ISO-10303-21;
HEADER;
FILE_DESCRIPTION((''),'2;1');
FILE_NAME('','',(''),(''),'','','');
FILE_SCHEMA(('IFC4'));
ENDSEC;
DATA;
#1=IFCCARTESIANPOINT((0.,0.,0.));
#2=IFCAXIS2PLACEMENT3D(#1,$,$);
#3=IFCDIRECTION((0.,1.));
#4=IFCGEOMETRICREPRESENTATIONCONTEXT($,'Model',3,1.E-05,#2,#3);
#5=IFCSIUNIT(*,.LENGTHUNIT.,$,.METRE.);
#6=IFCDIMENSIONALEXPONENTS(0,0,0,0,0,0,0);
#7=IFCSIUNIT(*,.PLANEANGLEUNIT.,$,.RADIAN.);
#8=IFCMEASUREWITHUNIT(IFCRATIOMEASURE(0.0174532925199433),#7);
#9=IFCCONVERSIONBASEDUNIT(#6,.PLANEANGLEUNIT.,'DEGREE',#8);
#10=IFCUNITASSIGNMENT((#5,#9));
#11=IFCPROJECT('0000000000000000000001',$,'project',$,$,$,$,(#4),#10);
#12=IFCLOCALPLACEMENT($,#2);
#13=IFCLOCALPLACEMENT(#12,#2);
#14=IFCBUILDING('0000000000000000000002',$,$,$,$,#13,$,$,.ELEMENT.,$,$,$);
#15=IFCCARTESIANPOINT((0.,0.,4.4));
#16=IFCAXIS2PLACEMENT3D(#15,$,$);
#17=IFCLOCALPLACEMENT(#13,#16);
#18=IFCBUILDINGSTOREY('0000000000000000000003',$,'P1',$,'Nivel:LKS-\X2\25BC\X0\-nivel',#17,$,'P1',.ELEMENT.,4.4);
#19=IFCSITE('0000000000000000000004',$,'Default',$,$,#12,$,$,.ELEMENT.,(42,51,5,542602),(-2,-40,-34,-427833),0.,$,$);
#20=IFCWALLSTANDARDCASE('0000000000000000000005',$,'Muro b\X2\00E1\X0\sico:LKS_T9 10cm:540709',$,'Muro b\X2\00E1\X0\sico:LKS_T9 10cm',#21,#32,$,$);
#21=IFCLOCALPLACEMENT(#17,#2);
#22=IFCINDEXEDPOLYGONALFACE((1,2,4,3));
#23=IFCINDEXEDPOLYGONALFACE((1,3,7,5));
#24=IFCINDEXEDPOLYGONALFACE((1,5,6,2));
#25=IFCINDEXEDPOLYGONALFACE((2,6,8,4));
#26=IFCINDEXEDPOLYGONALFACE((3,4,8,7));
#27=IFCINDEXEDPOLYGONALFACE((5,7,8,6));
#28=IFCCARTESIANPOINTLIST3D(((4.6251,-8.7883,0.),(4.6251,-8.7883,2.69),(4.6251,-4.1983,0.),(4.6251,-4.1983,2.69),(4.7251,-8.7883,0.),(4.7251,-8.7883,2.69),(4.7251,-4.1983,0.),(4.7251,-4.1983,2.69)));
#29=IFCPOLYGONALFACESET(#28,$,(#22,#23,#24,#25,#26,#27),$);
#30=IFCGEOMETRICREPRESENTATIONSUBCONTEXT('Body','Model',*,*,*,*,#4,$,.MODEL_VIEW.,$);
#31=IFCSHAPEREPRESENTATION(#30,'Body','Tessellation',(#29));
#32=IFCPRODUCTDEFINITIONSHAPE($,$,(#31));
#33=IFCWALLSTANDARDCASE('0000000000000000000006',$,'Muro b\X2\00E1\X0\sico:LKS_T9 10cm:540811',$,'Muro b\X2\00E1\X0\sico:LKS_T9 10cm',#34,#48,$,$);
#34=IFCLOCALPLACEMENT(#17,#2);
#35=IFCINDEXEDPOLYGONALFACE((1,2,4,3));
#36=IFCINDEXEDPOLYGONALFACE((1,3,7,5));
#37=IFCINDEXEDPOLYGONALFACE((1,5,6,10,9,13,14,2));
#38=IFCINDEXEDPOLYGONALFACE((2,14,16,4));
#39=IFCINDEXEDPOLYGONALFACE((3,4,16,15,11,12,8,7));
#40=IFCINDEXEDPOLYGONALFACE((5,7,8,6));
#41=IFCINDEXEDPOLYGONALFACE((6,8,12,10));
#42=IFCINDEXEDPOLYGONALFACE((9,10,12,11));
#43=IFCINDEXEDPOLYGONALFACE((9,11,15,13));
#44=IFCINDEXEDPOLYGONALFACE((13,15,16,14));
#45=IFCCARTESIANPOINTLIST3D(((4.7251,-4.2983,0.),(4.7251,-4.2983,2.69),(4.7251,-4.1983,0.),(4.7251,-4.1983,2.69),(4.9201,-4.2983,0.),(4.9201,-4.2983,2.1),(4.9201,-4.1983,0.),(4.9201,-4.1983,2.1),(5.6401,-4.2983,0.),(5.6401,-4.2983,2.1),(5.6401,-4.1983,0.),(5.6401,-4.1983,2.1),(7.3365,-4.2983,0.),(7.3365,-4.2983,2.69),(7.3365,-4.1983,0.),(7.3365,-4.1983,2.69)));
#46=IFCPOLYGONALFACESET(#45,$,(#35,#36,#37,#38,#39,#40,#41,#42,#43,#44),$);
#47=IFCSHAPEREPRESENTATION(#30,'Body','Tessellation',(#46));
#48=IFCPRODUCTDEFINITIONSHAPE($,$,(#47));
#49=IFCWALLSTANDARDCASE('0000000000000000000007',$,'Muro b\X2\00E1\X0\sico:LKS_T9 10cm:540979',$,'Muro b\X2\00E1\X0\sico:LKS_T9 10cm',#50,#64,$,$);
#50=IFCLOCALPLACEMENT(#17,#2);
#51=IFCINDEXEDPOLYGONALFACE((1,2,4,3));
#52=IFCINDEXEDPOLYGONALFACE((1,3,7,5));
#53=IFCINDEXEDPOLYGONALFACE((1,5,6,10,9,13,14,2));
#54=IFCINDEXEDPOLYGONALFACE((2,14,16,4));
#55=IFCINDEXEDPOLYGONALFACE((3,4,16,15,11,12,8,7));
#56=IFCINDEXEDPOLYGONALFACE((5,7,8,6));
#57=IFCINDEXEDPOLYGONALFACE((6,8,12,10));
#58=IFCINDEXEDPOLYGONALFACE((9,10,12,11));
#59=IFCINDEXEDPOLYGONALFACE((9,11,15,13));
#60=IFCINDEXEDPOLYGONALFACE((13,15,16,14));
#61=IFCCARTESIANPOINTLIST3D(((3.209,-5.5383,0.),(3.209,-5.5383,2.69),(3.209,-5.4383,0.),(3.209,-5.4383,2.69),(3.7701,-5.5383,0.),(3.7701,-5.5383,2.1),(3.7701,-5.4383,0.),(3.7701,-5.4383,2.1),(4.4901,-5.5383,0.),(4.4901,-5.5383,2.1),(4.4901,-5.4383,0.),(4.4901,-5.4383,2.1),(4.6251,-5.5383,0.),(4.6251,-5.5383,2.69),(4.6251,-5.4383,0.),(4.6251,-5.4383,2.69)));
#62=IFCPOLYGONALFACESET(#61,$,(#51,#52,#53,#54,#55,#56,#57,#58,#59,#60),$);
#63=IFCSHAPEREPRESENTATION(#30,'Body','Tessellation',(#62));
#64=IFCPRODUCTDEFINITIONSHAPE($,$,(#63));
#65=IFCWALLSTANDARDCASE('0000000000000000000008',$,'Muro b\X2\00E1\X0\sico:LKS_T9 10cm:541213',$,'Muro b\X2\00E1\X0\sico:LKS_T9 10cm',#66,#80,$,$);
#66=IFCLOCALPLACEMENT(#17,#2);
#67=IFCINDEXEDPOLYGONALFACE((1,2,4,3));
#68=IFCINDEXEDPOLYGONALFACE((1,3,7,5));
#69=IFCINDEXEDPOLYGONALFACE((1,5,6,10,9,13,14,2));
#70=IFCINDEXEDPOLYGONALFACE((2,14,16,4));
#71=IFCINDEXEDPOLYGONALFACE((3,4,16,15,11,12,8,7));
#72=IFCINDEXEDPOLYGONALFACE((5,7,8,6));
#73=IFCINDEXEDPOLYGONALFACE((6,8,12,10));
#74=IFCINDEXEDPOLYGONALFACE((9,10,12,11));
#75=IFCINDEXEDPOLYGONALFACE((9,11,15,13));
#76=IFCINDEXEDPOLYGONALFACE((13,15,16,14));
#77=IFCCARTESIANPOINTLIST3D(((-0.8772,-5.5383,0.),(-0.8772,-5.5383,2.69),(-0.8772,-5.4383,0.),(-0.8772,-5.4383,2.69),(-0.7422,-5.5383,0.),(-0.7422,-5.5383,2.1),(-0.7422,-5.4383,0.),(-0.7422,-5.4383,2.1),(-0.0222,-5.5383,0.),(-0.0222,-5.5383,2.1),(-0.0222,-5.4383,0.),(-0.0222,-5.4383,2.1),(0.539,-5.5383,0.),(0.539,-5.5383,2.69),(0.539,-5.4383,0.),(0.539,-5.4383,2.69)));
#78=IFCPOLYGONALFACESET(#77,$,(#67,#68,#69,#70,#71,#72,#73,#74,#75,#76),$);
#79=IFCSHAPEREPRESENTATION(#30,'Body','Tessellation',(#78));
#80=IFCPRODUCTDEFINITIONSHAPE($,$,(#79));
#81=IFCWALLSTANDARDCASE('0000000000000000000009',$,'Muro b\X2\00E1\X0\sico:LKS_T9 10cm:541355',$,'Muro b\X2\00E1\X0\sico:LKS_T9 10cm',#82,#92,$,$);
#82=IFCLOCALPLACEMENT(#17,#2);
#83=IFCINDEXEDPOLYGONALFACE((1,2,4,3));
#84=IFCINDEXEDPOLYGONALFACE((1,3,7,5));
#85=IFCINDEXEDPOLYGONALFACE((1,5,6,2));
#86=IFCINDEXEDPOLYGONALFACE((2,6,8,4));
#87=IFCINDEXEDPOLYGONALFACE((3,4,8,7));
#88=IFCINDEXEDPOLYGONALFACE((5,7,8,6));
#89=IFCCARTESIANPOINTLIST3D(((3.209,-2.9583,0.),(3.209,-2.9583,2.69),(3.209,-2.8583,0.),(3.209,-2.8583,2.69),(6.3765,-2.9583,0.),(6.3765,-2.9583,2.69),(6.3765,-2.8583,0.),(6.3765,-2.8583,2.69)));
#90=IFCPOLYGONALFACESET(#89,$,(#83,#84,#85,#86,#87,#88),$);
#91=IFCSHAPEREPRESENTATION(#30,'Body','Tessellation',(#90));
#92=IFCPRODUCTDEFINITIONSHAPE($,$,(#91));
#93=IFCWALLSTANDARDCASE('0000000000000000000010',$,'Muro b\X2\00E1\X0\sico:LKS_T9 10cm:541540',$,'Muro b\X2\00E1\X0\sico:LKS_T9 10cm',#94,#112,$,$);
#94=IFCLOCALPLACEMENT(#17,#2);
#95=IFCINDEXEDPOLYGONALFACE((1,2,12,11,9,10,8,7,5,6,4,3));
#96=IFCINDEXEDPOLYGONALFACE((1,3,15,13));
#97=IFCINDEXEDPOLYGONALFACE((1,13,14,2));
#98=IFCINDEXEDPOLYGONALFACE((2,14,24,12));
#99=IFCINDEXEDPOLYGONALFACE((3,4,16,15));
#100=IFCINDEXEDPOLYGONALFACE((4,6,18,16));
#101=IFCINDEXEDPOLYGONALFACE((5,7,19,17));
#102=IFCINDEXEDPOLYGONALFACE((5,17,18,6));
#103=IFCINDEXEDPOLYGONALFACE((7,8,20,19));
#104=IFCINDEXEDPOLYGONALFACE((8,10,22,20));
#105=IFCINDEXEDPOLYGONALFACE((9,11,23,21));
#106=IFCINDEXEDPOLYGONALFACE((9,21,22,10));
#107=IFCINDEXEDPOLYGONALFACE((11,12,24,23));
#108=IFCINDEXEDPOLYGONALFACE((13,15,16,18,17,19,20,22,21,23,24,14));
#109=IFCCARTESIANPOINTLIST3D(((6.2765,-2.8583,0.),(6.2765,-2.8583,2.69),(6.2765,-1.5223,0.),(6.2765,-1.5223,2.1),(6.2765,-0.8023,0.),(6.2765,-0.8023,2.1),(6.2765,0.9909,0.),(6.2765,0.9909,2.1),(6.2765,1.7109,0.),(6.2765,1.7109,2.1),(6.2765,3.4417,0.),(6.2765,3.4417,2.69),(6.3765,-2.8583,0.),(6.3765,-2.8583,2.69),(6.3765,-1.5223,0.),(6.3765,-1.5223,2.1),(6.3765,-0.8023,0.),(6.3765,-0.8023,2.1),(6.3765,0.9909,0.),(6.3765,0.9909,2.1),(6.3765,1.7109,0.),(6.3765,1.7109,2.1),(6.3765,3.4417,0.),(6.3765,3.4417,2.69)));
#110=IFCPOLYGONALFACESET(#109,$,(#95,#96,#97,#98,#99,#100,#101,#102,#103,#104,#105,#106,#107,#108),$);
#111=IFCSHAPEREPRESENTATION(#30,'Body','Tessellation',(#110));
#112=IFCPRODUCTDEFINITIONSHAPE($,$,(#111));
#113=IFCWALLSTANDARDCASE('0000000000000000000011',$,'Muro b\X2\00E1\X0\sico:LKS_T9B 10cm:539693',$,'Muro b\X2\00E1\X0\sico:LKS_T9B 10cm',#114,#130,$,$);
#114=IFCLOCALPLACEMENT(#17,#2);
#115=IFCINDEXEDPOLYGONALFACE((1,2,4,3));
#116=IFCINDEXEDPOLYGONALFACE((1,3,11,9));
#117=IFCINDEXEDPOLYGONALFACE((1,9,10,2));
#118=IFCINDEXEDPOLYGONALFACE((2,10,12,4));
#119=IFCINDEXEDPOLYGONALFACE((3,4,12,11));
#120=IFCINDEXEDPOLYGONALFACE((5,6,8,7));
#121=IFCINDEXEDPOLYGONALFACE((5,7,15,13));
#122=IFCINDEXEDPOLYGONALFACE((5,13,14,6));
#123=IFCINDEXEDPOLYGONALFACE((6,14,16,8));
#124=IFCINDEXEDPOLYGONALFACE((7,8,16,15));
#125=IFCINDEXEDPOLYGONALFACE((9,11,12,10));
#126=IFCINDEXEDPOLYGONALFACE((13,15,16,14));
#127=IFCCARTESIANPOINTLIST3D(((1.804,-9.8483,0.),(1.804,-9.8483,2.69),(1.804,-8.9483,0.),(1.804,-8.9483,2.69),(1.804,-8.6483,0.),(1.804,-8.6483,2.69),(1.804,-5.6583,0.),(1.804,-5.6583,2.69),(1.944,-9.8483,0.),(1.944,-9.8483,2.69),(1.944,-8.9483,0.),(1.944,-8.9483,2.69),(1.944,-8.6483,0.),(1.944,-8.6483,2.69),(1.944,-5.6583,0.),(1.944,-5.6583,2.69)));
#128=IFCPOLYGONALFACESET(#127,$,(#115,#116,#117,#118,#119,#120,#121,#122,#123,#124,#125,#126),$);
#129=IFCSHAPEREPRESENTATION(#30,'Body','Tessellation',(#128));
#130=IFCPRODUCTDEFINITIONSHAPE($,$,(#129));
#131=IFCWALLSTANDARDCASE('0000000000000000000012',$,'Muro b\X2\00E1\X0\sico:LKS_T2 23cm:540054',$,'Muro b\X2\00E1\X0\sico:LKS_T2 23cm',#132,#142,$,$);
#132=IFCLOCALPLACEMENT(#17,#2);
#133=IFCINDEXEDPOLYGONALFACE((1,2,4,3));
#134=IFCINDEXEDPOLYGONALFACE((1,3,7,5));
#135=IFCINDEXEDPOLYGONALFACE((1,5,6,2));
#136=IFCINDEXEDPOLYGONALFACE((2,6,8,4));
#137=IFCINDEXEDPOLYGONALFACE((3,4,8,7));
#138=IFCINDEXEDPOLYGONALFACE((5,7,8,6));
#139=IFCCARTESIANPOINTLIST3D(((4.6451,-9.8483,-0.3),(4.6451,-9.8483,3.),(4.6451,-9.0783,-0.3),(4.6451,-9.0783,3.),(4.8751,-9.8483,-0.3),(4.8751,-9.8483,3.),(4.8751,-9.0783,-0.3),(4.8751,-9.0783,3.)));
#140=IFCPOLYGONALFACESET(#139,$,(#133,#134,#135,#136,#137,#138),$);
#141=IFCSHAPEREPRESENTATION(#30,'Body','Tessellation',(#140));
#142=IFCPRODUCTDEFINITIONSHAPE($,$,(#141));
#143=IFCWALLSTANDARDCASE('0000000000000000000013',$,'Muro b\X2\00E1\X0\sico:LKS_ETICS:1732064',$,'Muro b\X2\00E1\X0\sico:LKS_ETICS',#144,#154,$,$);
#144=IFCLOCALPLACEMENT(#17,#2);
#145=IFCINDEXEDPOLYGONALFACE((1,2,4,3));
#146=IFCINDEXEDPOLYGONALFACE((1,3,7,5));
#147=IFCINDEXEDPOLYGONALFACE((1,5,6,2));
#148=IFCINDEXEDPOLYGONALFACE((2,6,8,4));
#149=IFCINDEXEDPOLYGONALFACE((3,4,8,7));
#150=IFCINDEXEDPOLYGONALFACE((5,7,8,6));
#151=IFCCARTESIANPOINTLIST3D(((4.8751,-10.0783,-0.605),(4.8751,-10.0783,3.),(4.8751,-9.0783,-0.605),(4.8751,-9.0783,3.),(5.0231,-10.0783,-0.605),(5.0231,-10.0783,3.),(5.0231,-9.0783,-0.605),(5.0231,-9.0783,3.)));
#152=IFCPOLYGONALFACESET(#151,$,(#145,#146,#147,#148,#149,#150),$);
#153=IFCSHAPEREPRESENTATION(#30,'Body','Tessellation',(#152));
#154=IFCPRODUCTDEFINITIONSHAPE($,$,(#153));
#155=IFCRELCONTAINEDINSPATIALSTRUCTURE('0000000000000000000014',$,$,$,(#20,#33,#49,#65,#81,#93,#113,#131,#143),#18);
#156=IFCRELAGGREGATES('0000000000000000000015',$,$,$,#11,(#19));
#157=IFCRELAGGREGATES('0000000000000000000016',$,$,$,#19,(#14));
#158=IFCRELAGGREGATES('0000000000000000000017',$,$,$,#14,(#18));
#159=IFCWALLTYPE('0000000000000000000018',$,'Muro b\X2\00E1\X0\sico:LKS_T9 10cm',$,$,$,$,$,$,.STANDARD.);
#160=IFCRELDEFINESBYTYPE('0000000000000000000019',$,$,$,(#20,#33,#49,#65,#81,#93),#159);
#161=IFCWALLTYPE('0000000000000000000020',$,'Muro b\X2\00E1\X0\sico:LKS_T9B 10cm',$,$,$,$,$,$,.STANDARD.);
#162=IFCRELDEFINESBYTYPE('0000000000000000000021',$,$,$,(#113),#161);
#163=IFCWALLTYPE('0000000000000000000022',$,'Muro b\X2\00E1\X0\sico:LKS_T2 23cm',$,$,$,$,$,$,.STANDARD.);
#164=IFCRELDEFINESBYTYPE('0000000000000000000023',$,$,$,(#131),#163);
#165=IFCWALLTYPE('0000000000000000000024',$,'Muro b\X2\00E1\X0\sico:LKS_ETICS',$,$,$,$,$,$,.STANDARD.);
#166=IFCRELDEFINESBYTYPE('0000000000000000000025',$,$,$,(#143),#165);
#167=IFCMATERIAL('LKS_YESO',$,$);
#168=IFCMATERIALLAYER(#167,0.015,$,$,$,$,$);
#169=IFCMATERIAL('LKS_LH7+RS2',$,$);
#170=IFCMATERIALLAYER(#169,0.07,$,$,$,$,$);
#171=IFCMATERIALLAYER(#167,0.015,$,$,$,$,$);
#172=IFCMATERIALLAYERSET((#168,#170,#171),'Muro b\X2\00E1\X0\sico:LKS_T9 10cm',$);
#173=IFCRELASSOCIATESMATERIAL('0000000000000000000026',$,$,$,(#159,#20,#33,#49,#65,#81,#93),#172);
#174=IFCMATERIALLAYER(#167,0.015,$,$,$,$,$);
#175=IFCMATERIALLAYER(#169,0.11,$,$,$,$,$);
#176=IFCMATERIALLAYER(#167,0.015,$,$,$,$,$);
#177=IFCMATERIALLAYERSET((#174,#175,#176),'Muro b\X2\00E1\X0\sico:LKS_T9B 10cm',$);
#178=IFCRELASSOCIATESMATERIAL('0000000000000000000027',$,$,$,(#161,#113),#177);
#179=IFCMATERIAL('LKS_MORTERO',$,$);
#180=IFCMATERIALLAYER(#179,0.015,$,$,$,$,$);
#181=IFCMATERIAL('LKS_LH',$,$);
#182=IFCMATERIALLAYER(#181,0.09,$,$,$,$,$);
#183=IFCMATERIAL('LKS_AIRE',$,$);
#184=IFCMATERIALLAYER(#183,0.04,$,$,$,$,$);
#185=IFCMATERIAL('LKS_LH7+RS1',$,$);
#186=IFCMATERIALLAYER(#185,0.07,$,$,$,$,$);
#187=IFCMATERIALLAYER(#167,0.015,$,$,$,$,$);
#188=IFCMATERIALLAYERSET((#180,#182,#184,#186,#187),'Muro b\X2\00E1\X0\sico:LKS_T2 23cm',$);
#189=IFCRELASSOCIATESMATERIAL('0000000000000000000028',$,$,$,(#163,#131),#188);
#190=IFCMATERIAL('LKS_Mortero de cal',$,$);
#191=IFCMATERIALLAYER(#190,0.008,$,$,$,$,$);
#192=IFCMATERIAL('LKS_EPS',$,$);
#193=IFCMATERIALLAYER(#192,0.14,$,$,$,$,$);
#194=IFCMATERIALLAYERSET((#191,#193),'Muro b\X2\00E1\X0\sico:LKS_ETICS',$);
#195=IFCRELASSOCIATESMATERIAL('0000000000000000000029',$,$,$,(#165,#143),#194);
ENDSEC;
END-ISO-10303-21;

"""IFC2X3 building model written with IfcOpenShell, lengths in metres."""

from ifc_helpers import new_model, entity, si_unit, converted_unit, direction, frame, frame_2d, origin, place, context, subcontext, project, spatial, rectangle, extrude, material, layer, layer_set, layer_usage, type_object, element, save


model = new_model("IFC2X3")

# Units and contexts
model_context = context("Model", 3, precision=1e-05, world=origin(), true_north=direction((0.0, 1.0)))
body_context = subcontext(model_context, "Body", "Model", "MODEL_VIEW")
ifc_project = project(units=[si_unit("LENGTHUNIT", "METRE"), converted_unit("PLANEANGLEUNIT", "DEGREE", entity("IfcRatioMeasure", 0.0174532925199433), si_unit("PLANEANGLEUNIT", "RADIAN"), dimensions=[0, 0, 0, 0, 0, 0, 0])], contexts=[model_context])

# Site, building, storey
site_placement = place(None, origin())
site = spatial("IfcSite", under=ifc_project, at=site_placement, Name="Default", CompositionType="ELEMENT", RefLatitude=(42, 51, 5, 542602), RefLongitude=(-2, -40, -34, -427833), RefElevation=0.0)
building_placement = place(site_placement, origin())
building = spatial("IfcBuilding", under=site, at=building_placement, CompositionType="ELEMENT")
storey_placement = place(building_placement, frame((0.0, 0.0, 4.4)))
storey = spatial("IfcBuildingStorey", under=building, at=storey_placement, Name="P1", ObjectType="Nivel:LKS-▼-nivel", LongName="P1", CompositionType="ELEMENT", Elevation=4.4)

# Shared definitions
ifc_material_1 = material(Name="LKS_MORTERO")
ifc_material_2 = material(Name="LKS_LH")
ifc_material_3 = material(Name="LKS_AIRE")
ifc_material_4 = material(Name="LKS_LH7+RS2")
ifc_material_5 = material(Name="LKS_YESO")

# Shared definitions
ifc_material_6 = material(Name="LKS_LH7+RS1")

# Wall
ifc_layer_1 = layer(ifc_material_5, 0.015)
ifc_layer_2 = layer(ifc_material_4, 0.07)
ifc_layer_3 = layer(ifc_material_5, 0.015)
ifc_layer_set_1 = layer_set([ifc_layer_1, ifc_layer_2, ifc_layer_3], Name="Muro básico:LKS_T9 10cm")
ifc_layer_usage_1 = layer_usage(ifc_layer_set_1, "AXIS2", "NEGATIVE", 0.05)
wall_type_1 = type_object("IfcWallType", Name="Muro básico:LKS_T9 10cm", PredefinedType="STANDARD", material=ifc_layer_set_1)
wall_1_placement = place(storey_placement, frame((4.6751, -8.7883, 0.0), z_axis=(0.0, 0.0, 1.0), x_axis=(0.0, 1.0, 0.0)))
element("IfcWallStandardCase", 1, at=wall_1_placement, inside=storey, type_object=wall_type_1, material=ifc_layer_usage_1, Name="Muro básico:LKS_T9 10cm:540709", ObjectType="Muro básico:LKS_T9 10cm", context=body_context, shape_type="SweptSolid", body=[
    extrude(rectangle(XDim=4.59, YDim=0.1, at=frame_2d((2.295, 0.0), x_axis=(-1.0, 0.0))), origin(), (0.0, 0.0, 1.0), 2.69),
])

# Walls, openings
ifc_layer_usage_2 = layer_usage(ifc_layer_set_1, "AXIS2", "NEGATIVE", 0.05)
wall_2_placement = place(storey_placement, frame((4.7251, -4.2483, 0.0)))
wall_2 = element("IfcWallStandardCase", 2, at=wall_2_placement, inside=storey, type_object=wall_type_1, material=ifc_layer_usage_2, Name="Muro básico:LKS_T9 10cm:540811", ObjectType="Muro básico:LKS_T9 10cm", context=body_context, shape_type="SweptSolid", body=[
    extrude(rectangle(XDim=2.6115, YDim=0.1, at=frame_2d((1.3057, 0.0), x_axis=(-1.0, 0.0))), origin(), (0.0, 0.0, 1.0), 2.69),
])
opening_1_placement = place(wall_2_placement, frame((0.915, 0.05, 0.0)))
element("IfcOpeningElement", 3, at=opening_1_placement, cuts=wall_2, ObjectType="Opening", context=body_context, shape_type="SweptSolid", body=[
    extrude(rectangle(XDim=2.1, YDim=0.72, at=frame_2d((1.05, 0.36), x_axis=(1.0, 0.0))), frame((0.0, 0.0, 0.0), z_axis=(0.0, -1.0, 0.0), x_axis=(0.0, 0.0, 1.0)), (0.0, 0.0, 1.0), 0.1),
])
ifc_layer_usage_3 = layer_usage(ifc_layer_set_1, "AXIS2", "POSITIVE", -0.05)
wall_3_placement = place(storey_placement, frame((3.209, -5.4883, 0.0)))
wall_3 = element("IfcWallStandardCase", 4, at=wall_3_placement, inside=storey, type_object=wall_type_1, material=ifc_layer_usage_3, Name="Muro básico:LKS_T9 10cm:540979", ObjectType="Muro básico:LKS_T9 10cm", context=body_context, shape_type="SweptSolid", body=[
    extrude(rectangle(XDim=1.4161, YDim=0.1, at=frame_2d((0.7081, 0.0), x_axis=(-1.0, 0.0))), origin(), (0.0, 0.0, 1.0), 2.69),
])
opening_2_placement = place(wall_3_placement, frame((1.2811, 0.05, 0.0)))
element("IfcOpeningElement", 5, at=opening_2_placement, cuts=wall_3, ObjectType="Opening", context=body_context, shape_type="SweptSolid", body=[
    extrude(rectangle(XDim=2.1, YDim=0.72, at=frame_2d((1.05, 0.36), x_axis=(1.0, 0.0))), frame((0.0, 0.0, 0.0), z_axis=(0.0, -1.0, 0.0), x_axis=(0.0, 0.0, 1.0)), (0.0, 0.0, 1.0), 0.1),
])
ifc_layer_usage_4 = layer_usage(ifc_layer_set_1, "AXIS2", "NEGATIVE", 0.05)
wall_4_placement = place(storey_placement, frame((0.539, -5.4883, 0.0), z_axis=(0.0, 0.0, 1.0), x_axis=(-1.0, 0.0, 0.0)))
wall_4 = element("IfcWallStandardCase", 6, at=wall_4_placement, inside=storey, type_object=wall_type_1, material=ifc_layer_usage_4, Name="Muro básico:LKS_T9 10cm:541213", ObjectType="Muro básico:LKS_T9 10cm", context=body_context, shape_type="SweptSolid", body=[
    extrude(rectangle(XDim=1.4161, YDim=0.1, at=frame_2d((0.7081, 0.0), x_axis=(-1.0, 0.0))), origin(), (0.0, 0.0, 1.0), 2.69),
])
opening_3_placement = place(wall_4_placement, frame((0.5611, -0.05, 0.0)))
element("IfcOpeningElement", 7, at=opening_3_placement, cuts=wall_4, ObjectType="Opening", context=body_context, shape_type="SweptSolid", body=[
    extrude(rectangle(XDim=2.1, YDim=0.72, at=frame_2d((1.05, 0.36), x_axis=(1.0, 0.0))), frame((0.0, 0.0, 0.0), z_axis=(0.0, 1.0, 0.0), x_axis=(0.0, 0.0, 1.0)), (0.0, 0.0, 1.0), 0.1),
])

# Wall
ifc_layer_usage_5 = layer_usage(ifc_layer_set_1, "AXIS2", "NEGATIVE", 0.05)
wall_5_placement = place(storey_placement, frame((3.209, -2.9083, 0.0)))
element("IfcWallStandardCase", 8, at=wall_5_placement, inside=storey, type_object=wall_type_1, material=ifc_layer_usage_5, Name="Muro básico:LKS_T9 10cm:541355", ObjectType="Muro básico:LKS_T9 10cm", context=body_context, shape_type="SweptSolid", body=[
    extrude(rectangle(XDim=3.1676, YDim=0.1, at=frame_2d((1.5838, 0.0), x_axis=(-1.0, 0.0))), origin(), (0.0, 0.0, 1.0), 2.69),
])

# Wall, openings
ifc_layer_usage_6 = layer_usage(ifc_layer_set_1, "AXIS2", "NEGATIVE", 0.05)
wall_6_placement = place(storey_placement, frame((6.3265, -2.8583, 0.0), z_axis=(0.0, 0.0, 1.0), x_axis=(0.0, 1.0, 0.0)))
wall_6 = element("IfcWallStandardCase", 9, at=wall_6_placement, inside=storey, type_object=wall_type_1, material=ifc_layer_usage_6, Name="Muro básico:LKS_T9 10cm:541540", ObjectType="Muro básico:LKS_T9 10cm", context=body_context, shape_type="SweptSolid", body=[
    extrude(rectangle(XDim=6.3, YDim=0.1, at=frame_2d((3.15, 0.0), x_axis=(-1.0, 0.0))), origin(), (0.0, 0.0, 1.0), 2.69),
])
opening_4_placement = place(wall_6_placement, frame((1.3359, -0.05, 0.0)))
element("IfcOpeningElement", 10, at=opening_4_placement, cuts=wall_6, ObjectType="Opening", context=body_context, shape_type="SweptSolid", body=[
    extrude(rectangle(XDim=2.1, YDim=0.72, at=frame_2d((1.05, 0.36), x_axis=(1.0, 0.0))), frame((0.0, 0.0, 0.0), z_axis=(0.0, 1.0, 0.0), x_axis=(0.0, 0.0, 1.0)), (0.0, 0.0, 1.0), 0.1),
])
opening_5_placement = place(wall_6_placement, frame((3.8492, -0.05, 0.0)))
element("IfcOpeningElement", 11, at=opening_5_placement, cuts=wall_6, ObjectType="Opening", context=body_context, shape_type="SweptSolid", body=[
    extrude(rectangle(XDim=2.1, YDim=0.72, at=frame_2d((1.05, 0.36), x_axis=(1.0, 0.0))), frame((0.0, 0.0, 0.0), z_axis=(0.0, 1.0, 0.0), x_axis=(0.0, 0.0, 1.0)), (0.0, 0.0, 1.0), 0.1),
])

# Wall, opening
ifc_layer_4 = layer(ifc_material_5, 0.015)
ifc_layer_5 = layer(ifc_material_4, 0.11)
ifc_layer_6 = layer(ifc_material_5, 0.015)
ifc_layer_set_2 = layer_set([ifc_layer_4, ifc_layer_5, ifc_layer_6], Name="Muro básico:LKS_T9B 10cm")
ifc_layer_usage_7 = layer_usage(ifc_layer_set_2, "AXIS2", "NEGATIVE", 0.07)
wall_type_2 = type_object("IfcWallType", Name="Muro básico:LKS_T9B 10cm", PredefinedType="STANDARD", material=ifc_layer_set_2)
wall_7_placement = place(storey_placement, frame((1.874, -5.6583, 0.0), z_axis=(0.0, 0.0, 1.0), x_axis=(0.0, -1.0, 0.0)))
wall_7 = element("IfcWallStandardCase", 12, at=wall_7_placement, inside=storey, type_object=wall_type_2, material=ifc_layer_usage_7, Name="Muro básico:LKS_T9B 10cm:539693", ObjectType="Muro básico:LKS_T9B 10cm", context=body_context, shape_type="SweptSolid", body=[
    extrude(rectangle(XDim=4.19, YDim=0.14, at=frame_2d((2.095, 0.0), x_axis=(-1.0, 0.0))), origin(), (0.0, 0.0, 1.0), 2.69),
])
opening_6_placement = place(storey_placement, frame((1.874, -5.6583, 0.0), z_axis=(0.0, 0.0, 1.0), x_axis=(0.0, -1.0, 0.0)))
element("IfcOpeningElement", 13, at=opening_6_placement, cuts=wall_7, ObjectType="Opening", context=body_context, shape_type="SweptSolid", body=[
    extrude(rectangle(XDim=2.69, YDim=0.14, at=frame_2d((0.0, 0.0), x_axis=(1.0, 0.0))), frame((3.29, 0.0, 1.345), z_axis=(-1.0, 0.0, 0.0), x_axis=(0.0, 0.0, 1.0)), (0.0, 0.0, 1.0), 0.3),
])

# Walls
ifc_layer_7 = layer(ifc_material_1, 0.015)
ifc_layer_8 = layer(ifc_material_2, 0.09)
ifc_layer_9 = layer(ifc_material_3, 0.04)
ifc_layer_10 = layer(ifc_material_6, 0.07)
ifc_layer_11 = layer(ifc_material_5, 0.015)
ifc_layer_set_3 = layer_set([ifc_layer_7, ifc_layer_8, ifc_layer_9, ifc_layer_10, ifc_layer_11], Name="Muro básico:LKS_T2 23cm")
ifc_layer_usage_8 = layer_usage(ifc_layer_set_3, "AXIS2", "POSITIVE", -0.115)
wall_type_3 = type_object("IfcWallType", Name="Muro básico:LKS_T2 23cm", PredefinedType="STANDARD", material=ifc_layer_set_3)
wall_8_placement = place(storey_placement, frame((4.7601, -9.8483, -0.3), z_axis=(0.0, 0.0, 1.0), x_axis=(0.0, 1.0, 0.0)))
element("IfcWallStandardCase", 14, at=wall_8_placement, inside=storey, type_object=wall_type_3, material=ifc_layer_usage_8, Name="Muro básico:LKS_T2 23cm:540054", ObjectType="Muro básico:LKS_T2 23cm", context=body_context, shape_type="SweptSolid", body=[
    extrude(rectangle(XDim=0.77, YDim=0.23, at=frame_2d((0.385, 0.0), x_axis=(-1.0, 0.0))), origin(), (0.0, 0.0, 1.0), 3.3),
])
ifc_material_7 = material(Name="LKS_Mortero de cal")
ifc_layer_12 = layer(ifc_material_7, 0.008)
ifc_material_8 = material(Name="LKS_EPS")
ifc_layer_13 = layer(ifc_material_8, 0.14)
ifc_layer_set_4 = layer_set([ifc_layer_12, ifc_layer_13], Name="Muro básico:LKS_ETICS")
ifc_layer_usage_9 = layer_usage(ifc_layer_set_4, "AXIS2", "POSITIVE", -0.074)
wall_type_4 = type_object("IfcWallType", Name="Muro básico:LKS_ETICS", PredefinedType="STANDARD", material=ifc_layer_set_4)
wall_9_placement = place(storey_placement, frame((4.9491, -10.0783, -0.605), z_axis=(0.0, 0.0, 1.0), x_axis=(0.0, 1.0, 0.0)))
element("IfcWallStandardCase", 15, at=wall_9_placement, inside=storey, type_object=wall_type_4, material=ifc_layer_usage_9, Name="Muro básico:LKS_ETICS:1732064", ObjectType="Muro básico:LKS_ETICS", context=body_context, shape_type="SweptSolid", body=[
    extrude(rectangle(XDim=1.0, YDim=0.148, at=frame_2d((0.5, 0.0), x_axis=(-1.0, 0.0))), origin(), (0.0, 0.0, 1.0), 3.605),
])

save(model, "model.ifc")
